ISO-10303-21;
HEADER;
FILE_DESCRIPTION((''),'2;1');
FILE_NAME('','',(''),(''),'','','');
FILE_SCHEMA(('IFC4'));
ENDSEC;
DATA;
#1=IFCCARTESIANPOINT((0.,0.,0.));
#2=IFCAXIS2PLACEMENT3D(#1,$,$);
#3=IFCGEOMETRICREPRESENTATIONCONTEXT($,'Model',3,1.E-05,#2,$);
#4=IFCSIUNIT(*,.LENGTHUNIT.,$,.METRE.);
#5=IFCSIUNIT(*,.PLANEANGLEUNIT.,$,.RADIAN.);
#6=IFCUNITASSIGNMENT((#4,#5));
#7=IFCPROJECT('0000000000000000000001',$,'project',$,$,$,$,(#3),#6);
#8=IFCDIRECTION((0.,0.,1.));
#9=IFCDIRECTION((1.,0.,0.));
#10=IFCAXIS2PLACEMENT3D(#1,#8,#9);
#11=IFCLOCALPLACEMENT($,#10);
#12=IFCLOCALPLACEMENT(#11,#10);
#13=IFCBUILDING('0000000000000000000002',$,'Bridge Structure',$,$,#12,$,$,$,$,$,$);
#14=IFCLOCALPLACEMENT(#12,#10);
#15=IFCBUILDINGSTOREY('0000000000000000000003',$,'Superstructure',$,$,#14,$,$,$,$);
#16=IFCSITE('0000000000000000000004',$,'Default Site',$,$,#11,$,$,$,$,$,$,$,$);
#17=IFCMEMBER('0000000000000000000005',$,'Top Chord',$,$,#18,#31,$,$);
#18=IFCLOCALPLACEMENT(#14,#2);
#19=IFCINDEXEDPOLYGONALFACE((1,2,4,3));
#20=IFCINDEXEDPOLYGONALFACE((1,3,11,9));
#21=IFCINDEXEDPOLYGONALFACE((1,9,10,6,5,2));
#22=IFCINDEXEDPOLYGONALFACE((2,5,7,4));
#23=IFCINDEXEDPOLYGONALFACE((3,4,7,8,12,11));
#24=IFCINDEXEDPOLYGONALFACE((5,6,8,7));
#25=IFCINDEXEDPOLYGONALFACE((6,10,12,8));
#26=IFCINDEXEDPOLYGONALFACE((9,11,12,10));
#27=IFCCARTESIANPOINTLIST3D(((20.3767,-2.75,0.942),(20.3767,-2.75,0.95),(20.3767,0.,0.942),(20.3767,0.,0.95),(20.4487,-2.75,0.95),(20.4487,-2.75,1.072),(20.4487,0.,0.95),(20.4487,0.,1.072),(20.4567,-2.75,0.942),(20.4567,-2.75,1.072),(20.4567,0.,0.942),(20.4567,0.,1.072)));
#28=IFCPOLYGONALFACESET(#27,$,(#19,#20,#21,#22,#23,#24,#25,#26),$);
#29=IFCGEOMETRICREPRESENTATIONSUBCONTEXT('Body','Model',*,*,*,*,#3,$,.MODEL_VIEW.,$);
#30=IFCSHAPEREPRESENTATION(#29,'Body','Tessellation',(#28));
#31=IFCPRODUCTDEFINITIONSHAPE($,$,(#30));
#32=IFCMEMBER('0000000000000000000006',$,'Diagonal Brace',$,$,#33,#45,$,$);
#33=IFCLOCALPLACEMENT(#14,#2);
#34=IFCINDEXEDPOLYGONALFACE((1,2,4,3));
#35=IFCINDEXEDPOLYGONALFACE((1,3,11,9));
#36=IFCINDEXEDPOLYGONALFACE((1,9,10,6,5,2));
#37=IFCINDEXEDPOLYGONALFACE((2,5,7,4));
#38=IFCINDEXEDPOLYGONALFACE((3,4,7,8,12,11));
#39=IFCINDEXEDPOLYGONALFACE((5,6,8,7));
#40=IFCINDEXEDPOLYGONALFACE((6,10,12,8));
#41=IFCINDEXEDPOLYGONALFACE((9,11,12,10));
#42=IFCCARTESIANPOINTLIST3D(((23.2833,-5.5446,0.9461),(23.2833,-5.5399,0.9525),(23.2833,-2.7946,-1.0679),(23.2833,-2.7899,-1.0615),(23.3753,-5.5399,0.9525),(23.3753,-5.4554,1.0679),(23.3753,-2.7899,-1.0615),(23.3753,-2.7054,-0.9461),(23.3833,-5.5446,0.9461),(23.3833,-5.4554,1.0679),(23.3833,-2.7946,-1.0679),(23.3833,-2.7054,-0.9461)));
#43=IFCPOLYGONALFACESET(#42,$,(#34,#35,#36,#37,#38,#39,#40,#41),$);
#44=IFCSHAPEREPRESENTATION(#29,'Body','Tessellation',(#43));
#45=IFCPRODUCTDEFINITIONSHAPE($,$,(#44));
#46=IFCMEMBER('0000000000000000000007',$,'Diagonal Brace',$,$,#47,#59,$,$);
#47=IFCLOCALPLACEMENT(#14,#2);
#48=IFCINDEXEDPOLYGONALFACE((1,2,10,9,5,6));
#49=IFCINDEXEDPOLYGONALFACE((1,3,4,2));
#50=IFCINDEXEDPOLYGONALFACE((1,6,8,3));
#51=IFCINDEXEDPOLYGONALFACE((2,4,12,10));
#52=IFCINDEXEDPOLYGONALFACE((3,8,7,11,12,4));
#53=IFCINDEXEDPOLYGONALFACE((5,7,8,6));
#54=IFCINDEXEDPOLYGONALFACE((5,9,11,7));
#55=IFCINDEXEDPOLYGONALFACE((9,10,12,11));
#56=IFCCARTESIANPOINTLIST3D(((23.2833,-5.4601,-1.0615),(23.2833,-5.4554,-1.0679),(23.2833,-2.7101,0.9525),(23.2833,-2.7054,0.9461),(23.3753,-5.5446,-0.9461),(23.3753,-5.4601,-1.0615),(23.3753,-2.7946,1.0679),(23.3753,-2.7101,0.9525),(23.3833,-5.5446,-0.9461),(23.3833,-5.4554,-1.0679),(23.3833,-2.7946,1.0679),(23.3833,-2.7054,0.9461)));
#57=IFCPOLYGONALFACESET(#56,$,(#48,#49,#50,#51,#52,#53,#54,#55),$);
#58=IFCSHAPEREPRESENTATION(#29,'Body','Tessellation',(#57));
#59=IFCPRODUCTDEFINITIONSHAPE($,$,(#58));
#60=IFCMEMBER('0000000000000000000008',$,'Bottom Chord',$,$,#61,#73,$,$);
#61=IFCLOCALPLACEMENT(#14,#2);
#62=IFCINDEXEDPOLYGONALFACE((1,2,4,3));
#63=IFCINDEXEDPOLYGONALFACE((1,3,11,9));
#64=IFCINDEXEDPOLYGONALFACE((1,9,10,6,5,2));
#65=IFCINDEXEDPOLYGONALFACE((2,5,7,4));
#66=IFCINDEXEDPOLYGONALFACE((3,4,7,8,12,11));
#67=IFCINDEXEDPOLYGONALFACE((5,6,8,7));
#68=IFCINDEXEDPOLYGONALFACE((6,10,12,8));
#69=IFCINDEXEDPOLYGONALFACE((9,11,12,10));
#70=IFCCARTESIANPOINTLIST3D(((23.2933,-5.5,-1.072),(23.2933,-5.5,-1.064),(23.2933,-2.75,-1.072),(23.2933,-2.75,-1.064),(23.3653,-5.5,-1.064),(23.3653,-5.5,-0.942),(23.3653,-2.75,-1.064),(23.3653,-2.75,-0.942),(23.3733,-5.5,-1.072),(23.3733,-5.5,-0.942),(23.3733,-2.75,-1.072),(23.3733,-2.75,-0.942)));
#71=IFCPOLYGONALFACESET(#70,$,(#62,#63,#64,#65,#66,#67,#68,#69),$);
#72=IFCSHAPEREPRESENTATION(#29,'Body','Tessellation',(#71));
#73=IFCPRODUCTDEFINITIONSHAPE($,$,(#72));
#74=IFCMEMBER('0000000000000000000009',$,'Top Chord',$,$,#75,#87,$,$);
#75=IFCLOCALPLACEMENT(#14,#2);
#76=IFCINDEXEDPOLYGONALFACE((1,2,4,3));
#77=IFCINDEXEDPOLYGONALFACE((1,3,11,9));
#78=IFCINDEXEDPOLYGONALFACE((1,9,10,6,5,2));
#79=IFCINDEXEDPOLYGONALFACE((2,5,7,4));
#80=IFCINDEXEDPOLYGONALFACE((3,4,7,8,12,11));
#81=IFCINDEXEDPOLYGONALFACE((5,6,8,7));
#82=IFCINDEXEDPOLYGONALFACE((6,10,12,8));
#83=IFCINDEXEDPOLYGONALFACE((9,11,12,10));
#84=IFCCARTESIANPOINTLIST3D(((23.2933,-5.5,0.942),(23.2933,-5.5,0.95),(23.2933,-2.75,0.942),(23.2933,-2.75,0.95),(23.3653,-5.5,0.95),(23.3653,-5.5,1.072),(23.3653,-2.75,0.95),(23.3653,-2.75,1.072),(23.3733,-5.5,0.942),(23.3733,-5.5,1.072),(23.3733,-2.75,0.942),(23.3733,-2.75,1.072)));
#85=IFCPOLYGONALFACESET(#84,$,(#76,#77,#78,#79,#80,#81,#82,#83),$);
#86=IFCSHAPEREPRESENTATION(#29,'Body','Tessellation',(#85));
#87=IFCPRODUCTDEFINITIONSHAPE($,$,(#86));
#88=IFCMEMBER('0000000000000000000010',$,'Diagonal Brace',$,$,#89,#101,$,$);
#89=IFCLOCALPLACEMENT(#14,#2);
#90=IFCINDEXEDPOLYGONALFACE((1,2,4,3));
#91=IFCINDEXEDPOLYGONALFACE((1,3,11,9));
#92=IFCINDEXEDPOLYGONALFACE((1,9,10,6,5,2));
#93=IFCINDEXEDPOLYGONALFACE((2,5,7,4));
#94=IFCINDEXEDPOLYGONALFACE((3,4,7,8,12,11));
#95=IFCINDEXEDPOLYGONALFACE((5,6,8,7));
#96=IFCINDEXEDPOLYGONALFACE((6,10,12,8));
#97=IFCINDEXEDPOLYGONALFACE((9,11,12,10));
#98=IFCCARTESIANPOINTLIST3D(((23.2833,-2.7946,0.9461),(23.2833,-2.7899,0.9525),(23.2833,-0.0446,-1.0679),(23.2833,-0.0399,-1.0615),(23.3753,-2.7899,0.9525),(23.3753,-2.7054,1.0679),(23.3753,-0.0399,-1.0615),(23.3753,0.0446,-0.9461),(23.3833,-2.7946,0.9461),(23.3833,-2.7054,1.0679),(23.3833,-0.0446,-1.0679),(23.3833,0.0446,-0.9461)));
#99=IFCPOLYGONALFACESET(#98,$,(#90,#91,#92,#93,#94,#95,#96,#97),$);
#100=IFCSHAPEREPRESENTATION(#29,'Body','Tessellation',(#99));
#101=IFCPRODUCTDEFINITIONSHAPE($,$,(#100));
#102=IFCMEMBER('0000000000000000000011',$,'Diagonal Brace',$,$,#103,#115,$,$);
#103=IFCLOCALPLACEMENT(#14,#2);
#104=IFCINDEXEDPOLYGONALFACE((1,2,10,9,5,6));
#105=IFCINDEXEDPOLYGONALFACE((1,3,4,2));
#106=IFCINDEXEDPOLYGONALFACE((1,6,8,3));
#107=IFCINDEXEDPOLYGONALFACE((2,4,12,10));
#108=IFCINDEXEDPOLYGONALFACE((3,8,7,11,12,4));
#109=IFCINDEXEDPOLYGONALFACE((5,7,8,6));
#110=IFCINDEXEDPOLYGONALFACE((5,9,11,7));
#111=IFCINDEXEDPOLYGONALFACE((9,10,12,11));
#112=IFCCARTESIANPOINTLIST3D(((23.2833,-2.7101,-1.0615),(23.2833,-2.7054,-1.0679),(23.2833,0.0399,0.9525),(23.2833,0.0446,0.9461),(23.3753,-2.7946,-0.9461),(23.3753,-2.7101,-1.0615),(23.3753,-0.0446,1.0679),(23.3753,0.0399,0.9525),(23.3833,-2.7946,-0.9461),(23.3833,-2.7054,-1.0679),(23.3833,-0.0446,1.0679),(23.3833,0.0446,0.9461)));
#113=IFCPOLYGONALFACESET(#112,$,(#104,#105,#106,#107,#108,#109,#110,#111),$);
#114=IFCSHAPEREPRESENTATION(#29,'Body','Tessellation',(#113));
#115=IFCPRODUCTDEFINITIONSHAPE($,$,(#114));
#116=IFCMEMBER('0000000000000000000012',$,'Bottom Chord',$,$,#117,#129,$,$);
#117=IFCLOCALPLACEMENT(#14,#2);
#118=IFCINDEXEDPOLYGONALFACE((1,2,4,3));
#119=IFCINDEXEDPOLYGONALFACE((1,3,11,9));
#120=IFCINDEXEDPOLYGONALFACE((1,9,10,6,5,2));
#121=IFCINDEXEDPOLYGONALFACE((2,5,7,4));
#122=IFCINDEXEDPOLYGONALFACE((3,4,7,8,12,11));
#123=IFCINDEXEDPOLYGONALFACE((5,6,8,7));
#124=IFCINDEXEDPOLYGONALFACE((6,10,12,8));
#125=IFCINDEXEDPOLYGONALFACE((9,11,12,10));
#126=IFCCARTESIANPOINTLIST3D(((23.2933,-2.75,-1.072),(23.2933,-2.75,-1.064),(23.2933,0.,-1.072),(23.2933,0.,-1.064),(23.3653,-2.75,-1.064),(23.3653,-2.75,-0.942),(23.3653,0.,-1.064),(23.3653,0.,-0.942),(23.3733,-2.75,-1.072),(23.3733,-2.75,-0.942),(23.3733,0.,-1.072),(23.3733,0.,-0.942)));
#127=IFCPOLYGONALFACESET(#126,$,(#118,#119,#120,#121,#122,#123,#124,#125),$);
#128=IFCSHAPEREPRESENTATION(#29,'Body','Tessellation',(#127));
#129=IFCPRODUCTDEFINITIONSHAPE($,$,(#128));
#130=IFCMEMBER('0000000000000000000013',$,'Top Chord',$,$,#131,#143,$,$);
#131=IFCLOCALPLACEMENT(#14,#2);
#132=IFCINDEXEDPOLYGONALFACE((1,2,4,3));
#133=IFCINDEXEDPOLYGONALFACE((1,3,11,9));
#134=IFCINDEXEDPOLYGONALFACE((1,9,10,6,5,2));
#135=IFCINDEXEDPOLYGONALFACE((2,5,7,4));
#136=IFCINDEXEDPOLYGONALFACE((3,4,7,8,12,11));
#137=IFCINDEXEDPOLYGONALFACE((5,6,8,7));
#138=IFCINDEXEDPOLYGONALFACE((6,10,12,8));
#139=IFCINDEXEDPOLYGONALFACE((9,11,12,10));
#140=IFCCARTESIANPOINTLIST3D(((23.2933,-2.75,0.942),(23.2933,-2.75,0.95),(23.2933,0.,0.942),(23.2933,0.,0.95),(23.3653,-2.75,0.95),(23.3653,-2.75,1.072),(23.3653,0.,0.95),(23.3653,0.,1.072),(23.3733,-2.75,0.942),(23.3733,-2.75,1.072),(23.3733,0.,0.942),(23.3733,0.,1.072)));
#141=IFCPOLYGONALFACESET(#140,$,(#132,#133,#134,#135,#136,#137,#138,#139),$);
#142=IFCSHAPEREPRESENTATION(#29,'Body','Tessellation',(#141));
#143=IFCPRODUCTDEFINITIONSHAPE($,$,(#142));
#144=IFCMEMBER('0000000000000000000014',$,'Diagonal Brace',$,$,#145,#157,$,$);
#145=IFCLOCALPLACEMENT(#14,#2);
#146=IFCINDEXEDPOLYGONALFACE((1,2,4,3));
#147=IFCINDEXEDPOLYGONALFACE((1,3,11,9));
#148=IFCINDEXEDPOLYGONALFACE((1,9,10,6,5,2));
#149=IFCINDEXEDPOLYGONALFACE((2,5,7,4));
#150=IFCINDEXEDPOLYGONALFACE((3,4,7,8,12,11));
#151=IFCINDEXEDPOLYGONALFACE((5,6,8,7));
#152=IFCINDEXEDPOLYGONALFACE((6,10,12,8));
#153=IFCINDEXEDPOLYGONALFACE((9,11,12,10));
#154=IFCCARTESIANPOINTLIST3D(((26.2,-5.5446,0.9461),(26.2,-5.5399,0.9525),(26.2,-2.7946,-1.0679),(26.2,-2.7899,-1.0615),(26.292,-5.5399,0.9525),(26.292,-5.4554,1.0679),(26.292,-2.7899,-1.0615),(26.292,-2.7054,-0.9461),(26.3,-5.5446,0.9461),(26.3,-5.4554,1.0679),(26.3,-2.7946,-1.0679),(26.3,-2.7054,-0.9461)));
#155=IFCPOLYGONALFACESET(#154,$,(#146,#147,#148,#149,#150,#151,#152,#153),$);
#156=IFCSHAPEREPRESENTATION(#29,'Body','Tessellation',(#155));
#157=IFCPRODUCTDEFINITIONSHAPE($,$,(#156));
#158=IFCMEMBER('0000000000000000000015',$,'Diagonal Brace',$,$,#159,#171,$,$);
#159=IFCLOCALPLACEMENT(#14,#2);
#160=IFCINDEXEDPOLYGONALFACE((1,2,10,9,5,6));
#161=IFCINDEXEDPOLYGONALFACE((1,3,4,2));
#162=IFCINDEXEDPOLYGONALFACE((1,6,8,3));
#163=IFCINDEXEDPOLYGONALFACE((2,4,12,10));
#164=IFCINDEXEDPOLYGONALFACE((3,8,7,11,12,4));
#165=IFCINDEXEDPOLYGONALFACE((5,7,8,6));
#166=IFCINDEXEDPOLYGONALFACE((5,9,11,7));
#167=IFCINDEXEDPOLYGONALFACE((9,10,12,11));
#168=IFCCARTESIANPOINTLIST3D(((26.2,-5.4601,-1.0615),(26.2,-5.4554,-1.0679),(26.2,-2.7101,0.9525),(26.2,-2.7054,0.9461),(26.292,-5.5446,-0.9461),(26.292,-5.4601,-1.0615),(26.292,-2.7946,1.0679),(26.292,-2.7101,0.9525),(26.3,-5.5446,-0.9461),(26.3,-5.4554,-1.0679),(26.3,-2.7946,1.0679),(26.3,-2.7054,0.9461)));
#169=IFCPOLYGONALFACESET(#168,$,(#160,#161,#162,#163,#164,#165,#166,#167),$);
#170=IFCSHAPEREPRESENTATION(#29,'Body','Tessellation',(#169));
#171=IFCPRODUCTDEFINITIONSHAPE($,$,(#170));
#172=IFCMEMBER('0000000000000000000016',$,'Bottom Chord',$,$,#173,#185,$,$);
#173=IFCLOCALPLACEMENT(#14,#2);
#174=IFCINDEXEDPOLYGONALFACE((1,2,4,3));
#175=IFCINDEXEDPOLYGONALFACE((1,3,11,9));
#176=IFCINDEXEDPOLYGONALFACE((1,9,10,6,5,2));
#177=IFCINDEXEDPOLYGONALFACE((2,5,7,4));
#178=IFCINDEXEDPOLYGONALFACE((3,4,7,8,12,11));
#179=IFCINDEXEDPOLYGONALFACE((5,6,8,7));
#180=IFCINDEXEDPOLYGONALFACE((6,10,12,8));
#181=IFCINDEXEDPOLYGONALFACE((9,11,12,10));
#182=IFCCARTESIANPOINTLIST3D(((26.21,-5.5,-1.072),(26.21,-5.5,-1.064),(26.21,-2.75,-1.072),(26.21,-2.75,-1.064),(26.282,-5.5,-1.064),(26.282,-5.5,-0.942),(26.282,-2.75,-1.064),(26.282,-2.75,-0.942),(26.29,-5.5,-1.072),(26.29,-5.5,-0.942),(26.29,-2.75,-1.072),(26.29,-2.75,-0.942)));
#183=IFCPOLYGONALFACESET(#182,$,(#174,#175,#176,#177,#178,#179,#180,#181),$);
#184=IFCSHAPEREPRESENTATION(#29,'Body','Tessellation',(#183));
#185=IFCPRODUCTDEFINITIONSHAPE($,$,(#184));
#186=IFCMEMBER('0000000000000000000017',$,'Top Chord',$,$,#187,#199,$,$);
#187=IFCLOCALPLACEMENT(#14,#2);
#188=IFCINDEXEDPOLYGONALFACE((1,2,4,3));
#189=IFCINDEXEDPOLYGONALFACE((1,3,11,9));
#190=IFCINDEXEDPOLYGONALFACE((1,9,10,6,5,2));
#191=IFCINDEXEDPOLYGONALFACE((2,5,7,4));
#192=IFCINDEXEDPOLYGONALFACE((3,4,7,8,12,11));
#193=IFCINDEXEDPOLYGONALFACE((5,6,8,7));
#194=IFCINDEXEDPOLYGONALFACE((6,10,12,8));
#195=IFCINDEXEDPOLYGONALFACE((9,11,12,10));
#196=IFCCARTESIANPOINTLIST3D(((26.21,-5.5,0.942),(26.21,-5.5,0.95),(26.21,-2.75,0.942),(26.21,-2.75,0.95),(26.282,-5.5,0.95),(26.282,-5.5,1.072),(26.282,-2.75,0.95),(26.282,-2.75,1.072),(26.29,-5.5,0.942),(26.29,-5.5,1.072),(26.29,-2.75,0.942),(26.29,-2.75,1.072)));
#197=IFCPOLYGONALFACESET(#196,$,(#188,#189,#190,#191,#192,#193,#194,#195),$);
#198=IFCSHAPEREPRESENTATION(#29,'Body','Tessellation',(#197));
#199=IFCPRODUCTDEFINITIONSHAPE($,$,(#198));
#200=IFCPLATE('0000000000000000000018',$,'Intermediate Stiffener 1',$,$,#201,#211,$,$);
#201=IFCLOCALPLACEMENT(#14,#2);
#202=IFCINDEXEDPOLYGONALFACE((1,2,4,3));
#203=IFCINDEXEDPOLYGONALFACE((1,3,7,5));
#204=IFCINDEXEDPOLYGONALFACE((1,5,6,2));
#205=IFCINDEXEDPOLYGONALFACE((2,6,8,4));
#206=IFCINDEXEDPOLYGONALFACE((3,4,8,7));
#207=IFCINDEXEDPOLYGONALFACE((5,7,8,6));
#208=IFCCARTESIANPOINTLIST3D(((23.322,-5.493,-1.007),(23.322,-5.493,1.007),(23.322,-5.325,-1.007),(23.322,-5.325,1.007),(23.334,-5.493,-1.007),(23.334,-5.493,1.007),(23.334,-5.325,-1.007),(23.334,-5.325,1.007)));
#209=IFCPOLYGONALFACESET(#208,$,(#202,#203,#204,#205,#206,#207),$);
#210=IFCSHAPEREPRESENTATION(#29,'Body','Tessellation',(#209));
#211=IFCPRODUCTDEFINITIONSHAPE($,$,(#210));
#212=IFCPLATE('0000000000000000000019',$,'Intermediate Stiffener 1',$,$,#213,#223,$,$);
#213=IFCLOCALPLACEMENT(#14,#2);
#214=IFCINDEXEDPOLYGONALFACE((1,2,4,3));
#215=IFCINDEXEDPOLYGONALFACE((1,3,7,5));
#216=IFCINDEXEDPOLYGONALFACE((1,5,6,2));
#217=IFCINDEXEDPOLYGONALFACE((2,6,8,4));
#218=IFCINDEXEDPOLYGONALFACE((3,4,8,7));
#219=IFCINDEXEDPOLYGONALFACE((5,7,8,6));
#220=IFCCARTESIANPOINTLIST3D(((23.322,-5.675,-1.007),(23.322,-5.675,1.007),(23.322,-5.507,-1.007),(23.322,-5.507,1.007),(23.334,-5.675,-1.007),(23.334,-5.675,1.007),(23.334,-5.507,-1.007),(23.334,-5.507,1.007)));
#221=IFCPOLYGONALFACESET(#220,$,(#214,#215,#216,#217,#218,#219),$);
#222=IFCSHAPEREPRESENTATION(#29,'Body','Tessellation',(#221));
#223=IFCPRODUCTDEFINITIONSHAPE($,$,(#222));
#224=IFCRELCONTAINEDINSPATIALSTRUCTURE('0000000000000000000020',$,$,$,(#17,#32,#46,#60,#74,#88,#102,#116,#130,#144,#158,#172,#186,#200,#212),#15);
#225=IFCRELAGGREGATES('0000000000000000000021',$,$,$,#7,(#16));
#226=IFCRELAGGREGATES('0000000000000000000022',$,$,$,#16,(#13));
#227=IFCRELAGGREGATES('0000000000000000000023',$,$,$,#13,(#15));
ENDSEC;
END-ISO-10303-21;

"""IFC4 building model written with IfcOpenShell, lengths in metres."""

from ifc_helpers import new_model, si_unit, frame, origin, origin_with_axes, origin_2d_with_axis, place, context, subcontext, project, spatial, rectangle, l_section, extrude, element, save


model = new_model("IFC4")

# Units and contexts
model_context = context("Model", 3, precision=1e-05, world=origin())
body_context = subcontext(model_context, "Body", "Model", "MODEL_VIEW")
ifc_project = project(units=[si_unit("LENGTHUNIT", "METRE"), si_unit("PLANEANGLEUNIT", "RADIAN")], contexts=[model_context])

# Site, building, storey
site_placement = place(None, origin_with_axes())
site = spatial("IfcSite", under=ifc_project, at=site_placement, Name="Default Site")
building_placement = place(site_placement, origin_with_axes())
building = spatial("IfcBuilding", under=site, at=building_placement, Name="Bridge Structure")
storey_placement = place(building_placement, origin_with_axes())
storey = spatial("IfcBuildingStorey", under=building, at=storey_placement, Name="Superstructure")

# Members
member_placement = place(storey_placement, frame((20.4167, -2.75, 1.007), z_axis=(0.0, 1.0, 0.0), x_axis=(-1.0, 0.0, 0.0)))
element("IfcMember", 1, at=member_placement, inside=storey, Name="Top Chord", context=body_context, shape_type="SweptSolid", body=[
    extrude(l_section(Depth=0.13, Width=0.08, Thickness=0.008, at=origin_2d_with_axis()), origin_with_axes(), (0.0, 0.0, 1.0), 2.75),
])
for number, where, z_axis, x_axis, name in (
    (2, (23.3333, -5.5, 1.007), (0.0, 0.806778, -0.590855), (-1.0, 0.0, 0.0), "Diagonal Brace"),
    (3, (23.3333, -5.5, -1.007), (0.0, 0.806778, 0.590855), (-1.0, 0.0, 0.0), "Diagonal Brace"),
):
    element("IfcMember", number, at=place(storey_placement, frame(where, z_axis=z_axis, x_axis=x_axis)), inside=storey, Name=name, context=body_context, shape_type="SweptSolid", body=[
        extrude(l_section(Depth=0.151, Width=0.1, Thickness=0.008, at=origin_2d_with_axis()), origin_with_axes(), (0.0, 0.0, 1.0), 3.4086),
    ])
for number, where, z_axis, x_axis, name in (
    (4, (23.3333, -5.5, -1.007), (0.0, 1.0, 0.0), (-1.0, 0.0, 0.0), "Bottom Chord"),
    (5, (23.3333, -5.5, 1.007), (0.0, 1.0, 0.0), (-1.0, 0.0, 0.0), "Top Chord"),
):
    element("IfcMember", number, at=place(storey_placement, frame(where, z_axis=z_axis, x_axis=x_axis)), inside=storey, Name=name, context=body_context, shape_type="SweptSolid", body=[
        extrude(l_section(Depth=0.13, Width=0.08, Thickness=0.008, at=origin_2d_with_axis()), origin_with_axes(), (0.0, 0.0, 1.0), 2.75),
    ])
for number, where, z_axis, x_axis, name in (
    (6, (23.3333, -2.75, 1.007), (0.0, 0.806778, -0.590855), (-1.0, 0.0, 0.0), "Diagonal Brace"),
    (7, (23.3333, -2.75, -1.007), (0.0, 0.806778, 0.590855), (-1.0, 0.0, 0.0), "Diagonal Brace"),
):
    element("IfcMember", number, at=place(storey_placement, frame(where, z_axis=z_axis, x_axis=x_axis)), inside=storey, Name=name, context=body_context, shape_type="SweptSolid", body=[
        extrude(l_section(Depth=0.151, Width=0.1, Thickness=0.008, at=origin_2d_with_axis()), origin_with_axes(), (0.0, 0.0, 1.0), 3.4086),
    ])
for number, where, z_axis, x_axis, name in (
    (8, (23.3333, -2.75, -1.007), (0.0, 1.0, 0.0), (-1.0, 0.0, 0.0), "Bottom Chord"),
    (9, (23.3333, -2.75, 1.007), (0.0, 1.0, 0.0), (-1.0, 0.0, 0.0), "Top Chord"),
):
    element("IfcMember", number, at=place(storey_placement, frame(where, z_axis=z_axis, x_axis=x_axis)), inside=storey, Name=name, context=body_context, shape_type="SweptSolid", body=[
        extrude(l_section(Depth=0.13, Width=0.08, Thickness=0.008, at=origin_2d_with_axis()), origin_with_axes(), (0.0, 0.0, 1.0), 2.75),
    ])
for number, where, z_axis, x_axis, name in (
    (10, (26.25, -5.5, 1.007), (0.0, 0.806778, -0.590855), (-1.0, 0.0, 0.0), "Diagonal Brace"),
    (11, (26.25, -5.5, -1.007), (0.0, 0.806778, 0.590855), (-1.0, 0.0, 0.0), "Diagonal Brace"),
):
    element("IfcMember", number, at=place(storey_placement, frame(where, z_axis=z_axis, x_axis=x_axis)), inside=storey, Name=name, context=body_context, shape_type="SweptSolid", body=[
        extrude(l_section(Depth=0.151, Width=0.1, Thickness=0.008, at=origin_2d_with_axis()), origin_with_axes(), (0.0, 0.0, 1.0), 3.4086),
    ])
for number, where, z_axis, x_axis, name in (
    (12, (26.25, -5.5, -1.007), (0.0, 1.0, 0.0), (-1.0, 0.0, 0.0), "Bottom Chord"),
    (13, (26.25, -5.5, 1.007), (0.0, 1.0, 0.0), (-1.0, 0.0, 0.0), "Top Chord"),
):
    element("IfcMember", number, at=place(storey_placement, frame(where, z_axis=z_axis, x_axis=x_axis)), inside=storey, Name=name, context=body_context, shape_type="SweptSolid", body=[
        extrude(l_section(Depth=0.13, Width=0.08, Thickness=0.008, at=origin_2d_with_axis()), origin_with_axes(), (0.0, 0.0, 1.0), 2.75),
    ])

# Plates
for number, where, z_axis, x_axis, name in (
    (14, (23.328, -5.409, -1.007), (0.0, 0.0, 1.0), (1.0, 0.0, 0.0), "Intermediate Stiffener 1"),
    (15, (23.328, -5.591, -1.007), (0.0, 0.0, 1.0), (1.0, 0.0, 0.0), "Intermediate Stiffener 1"),
):
    element("IfcPlate", number, at=place(storey_placement, frame(where, z_axis=z_axis, x_axis=x_axis)), inside=storey, Name=name, context=body_context, shape_type="SweptSolid", body=[
        extrude(rectangle(XDim=0.012, YDim=0.168, at=origin_2d_with_axis()), origin_with_axes(), (0.0, 0.0, 1.0), 2.014),
    ])

save(model, "model.ifc")
